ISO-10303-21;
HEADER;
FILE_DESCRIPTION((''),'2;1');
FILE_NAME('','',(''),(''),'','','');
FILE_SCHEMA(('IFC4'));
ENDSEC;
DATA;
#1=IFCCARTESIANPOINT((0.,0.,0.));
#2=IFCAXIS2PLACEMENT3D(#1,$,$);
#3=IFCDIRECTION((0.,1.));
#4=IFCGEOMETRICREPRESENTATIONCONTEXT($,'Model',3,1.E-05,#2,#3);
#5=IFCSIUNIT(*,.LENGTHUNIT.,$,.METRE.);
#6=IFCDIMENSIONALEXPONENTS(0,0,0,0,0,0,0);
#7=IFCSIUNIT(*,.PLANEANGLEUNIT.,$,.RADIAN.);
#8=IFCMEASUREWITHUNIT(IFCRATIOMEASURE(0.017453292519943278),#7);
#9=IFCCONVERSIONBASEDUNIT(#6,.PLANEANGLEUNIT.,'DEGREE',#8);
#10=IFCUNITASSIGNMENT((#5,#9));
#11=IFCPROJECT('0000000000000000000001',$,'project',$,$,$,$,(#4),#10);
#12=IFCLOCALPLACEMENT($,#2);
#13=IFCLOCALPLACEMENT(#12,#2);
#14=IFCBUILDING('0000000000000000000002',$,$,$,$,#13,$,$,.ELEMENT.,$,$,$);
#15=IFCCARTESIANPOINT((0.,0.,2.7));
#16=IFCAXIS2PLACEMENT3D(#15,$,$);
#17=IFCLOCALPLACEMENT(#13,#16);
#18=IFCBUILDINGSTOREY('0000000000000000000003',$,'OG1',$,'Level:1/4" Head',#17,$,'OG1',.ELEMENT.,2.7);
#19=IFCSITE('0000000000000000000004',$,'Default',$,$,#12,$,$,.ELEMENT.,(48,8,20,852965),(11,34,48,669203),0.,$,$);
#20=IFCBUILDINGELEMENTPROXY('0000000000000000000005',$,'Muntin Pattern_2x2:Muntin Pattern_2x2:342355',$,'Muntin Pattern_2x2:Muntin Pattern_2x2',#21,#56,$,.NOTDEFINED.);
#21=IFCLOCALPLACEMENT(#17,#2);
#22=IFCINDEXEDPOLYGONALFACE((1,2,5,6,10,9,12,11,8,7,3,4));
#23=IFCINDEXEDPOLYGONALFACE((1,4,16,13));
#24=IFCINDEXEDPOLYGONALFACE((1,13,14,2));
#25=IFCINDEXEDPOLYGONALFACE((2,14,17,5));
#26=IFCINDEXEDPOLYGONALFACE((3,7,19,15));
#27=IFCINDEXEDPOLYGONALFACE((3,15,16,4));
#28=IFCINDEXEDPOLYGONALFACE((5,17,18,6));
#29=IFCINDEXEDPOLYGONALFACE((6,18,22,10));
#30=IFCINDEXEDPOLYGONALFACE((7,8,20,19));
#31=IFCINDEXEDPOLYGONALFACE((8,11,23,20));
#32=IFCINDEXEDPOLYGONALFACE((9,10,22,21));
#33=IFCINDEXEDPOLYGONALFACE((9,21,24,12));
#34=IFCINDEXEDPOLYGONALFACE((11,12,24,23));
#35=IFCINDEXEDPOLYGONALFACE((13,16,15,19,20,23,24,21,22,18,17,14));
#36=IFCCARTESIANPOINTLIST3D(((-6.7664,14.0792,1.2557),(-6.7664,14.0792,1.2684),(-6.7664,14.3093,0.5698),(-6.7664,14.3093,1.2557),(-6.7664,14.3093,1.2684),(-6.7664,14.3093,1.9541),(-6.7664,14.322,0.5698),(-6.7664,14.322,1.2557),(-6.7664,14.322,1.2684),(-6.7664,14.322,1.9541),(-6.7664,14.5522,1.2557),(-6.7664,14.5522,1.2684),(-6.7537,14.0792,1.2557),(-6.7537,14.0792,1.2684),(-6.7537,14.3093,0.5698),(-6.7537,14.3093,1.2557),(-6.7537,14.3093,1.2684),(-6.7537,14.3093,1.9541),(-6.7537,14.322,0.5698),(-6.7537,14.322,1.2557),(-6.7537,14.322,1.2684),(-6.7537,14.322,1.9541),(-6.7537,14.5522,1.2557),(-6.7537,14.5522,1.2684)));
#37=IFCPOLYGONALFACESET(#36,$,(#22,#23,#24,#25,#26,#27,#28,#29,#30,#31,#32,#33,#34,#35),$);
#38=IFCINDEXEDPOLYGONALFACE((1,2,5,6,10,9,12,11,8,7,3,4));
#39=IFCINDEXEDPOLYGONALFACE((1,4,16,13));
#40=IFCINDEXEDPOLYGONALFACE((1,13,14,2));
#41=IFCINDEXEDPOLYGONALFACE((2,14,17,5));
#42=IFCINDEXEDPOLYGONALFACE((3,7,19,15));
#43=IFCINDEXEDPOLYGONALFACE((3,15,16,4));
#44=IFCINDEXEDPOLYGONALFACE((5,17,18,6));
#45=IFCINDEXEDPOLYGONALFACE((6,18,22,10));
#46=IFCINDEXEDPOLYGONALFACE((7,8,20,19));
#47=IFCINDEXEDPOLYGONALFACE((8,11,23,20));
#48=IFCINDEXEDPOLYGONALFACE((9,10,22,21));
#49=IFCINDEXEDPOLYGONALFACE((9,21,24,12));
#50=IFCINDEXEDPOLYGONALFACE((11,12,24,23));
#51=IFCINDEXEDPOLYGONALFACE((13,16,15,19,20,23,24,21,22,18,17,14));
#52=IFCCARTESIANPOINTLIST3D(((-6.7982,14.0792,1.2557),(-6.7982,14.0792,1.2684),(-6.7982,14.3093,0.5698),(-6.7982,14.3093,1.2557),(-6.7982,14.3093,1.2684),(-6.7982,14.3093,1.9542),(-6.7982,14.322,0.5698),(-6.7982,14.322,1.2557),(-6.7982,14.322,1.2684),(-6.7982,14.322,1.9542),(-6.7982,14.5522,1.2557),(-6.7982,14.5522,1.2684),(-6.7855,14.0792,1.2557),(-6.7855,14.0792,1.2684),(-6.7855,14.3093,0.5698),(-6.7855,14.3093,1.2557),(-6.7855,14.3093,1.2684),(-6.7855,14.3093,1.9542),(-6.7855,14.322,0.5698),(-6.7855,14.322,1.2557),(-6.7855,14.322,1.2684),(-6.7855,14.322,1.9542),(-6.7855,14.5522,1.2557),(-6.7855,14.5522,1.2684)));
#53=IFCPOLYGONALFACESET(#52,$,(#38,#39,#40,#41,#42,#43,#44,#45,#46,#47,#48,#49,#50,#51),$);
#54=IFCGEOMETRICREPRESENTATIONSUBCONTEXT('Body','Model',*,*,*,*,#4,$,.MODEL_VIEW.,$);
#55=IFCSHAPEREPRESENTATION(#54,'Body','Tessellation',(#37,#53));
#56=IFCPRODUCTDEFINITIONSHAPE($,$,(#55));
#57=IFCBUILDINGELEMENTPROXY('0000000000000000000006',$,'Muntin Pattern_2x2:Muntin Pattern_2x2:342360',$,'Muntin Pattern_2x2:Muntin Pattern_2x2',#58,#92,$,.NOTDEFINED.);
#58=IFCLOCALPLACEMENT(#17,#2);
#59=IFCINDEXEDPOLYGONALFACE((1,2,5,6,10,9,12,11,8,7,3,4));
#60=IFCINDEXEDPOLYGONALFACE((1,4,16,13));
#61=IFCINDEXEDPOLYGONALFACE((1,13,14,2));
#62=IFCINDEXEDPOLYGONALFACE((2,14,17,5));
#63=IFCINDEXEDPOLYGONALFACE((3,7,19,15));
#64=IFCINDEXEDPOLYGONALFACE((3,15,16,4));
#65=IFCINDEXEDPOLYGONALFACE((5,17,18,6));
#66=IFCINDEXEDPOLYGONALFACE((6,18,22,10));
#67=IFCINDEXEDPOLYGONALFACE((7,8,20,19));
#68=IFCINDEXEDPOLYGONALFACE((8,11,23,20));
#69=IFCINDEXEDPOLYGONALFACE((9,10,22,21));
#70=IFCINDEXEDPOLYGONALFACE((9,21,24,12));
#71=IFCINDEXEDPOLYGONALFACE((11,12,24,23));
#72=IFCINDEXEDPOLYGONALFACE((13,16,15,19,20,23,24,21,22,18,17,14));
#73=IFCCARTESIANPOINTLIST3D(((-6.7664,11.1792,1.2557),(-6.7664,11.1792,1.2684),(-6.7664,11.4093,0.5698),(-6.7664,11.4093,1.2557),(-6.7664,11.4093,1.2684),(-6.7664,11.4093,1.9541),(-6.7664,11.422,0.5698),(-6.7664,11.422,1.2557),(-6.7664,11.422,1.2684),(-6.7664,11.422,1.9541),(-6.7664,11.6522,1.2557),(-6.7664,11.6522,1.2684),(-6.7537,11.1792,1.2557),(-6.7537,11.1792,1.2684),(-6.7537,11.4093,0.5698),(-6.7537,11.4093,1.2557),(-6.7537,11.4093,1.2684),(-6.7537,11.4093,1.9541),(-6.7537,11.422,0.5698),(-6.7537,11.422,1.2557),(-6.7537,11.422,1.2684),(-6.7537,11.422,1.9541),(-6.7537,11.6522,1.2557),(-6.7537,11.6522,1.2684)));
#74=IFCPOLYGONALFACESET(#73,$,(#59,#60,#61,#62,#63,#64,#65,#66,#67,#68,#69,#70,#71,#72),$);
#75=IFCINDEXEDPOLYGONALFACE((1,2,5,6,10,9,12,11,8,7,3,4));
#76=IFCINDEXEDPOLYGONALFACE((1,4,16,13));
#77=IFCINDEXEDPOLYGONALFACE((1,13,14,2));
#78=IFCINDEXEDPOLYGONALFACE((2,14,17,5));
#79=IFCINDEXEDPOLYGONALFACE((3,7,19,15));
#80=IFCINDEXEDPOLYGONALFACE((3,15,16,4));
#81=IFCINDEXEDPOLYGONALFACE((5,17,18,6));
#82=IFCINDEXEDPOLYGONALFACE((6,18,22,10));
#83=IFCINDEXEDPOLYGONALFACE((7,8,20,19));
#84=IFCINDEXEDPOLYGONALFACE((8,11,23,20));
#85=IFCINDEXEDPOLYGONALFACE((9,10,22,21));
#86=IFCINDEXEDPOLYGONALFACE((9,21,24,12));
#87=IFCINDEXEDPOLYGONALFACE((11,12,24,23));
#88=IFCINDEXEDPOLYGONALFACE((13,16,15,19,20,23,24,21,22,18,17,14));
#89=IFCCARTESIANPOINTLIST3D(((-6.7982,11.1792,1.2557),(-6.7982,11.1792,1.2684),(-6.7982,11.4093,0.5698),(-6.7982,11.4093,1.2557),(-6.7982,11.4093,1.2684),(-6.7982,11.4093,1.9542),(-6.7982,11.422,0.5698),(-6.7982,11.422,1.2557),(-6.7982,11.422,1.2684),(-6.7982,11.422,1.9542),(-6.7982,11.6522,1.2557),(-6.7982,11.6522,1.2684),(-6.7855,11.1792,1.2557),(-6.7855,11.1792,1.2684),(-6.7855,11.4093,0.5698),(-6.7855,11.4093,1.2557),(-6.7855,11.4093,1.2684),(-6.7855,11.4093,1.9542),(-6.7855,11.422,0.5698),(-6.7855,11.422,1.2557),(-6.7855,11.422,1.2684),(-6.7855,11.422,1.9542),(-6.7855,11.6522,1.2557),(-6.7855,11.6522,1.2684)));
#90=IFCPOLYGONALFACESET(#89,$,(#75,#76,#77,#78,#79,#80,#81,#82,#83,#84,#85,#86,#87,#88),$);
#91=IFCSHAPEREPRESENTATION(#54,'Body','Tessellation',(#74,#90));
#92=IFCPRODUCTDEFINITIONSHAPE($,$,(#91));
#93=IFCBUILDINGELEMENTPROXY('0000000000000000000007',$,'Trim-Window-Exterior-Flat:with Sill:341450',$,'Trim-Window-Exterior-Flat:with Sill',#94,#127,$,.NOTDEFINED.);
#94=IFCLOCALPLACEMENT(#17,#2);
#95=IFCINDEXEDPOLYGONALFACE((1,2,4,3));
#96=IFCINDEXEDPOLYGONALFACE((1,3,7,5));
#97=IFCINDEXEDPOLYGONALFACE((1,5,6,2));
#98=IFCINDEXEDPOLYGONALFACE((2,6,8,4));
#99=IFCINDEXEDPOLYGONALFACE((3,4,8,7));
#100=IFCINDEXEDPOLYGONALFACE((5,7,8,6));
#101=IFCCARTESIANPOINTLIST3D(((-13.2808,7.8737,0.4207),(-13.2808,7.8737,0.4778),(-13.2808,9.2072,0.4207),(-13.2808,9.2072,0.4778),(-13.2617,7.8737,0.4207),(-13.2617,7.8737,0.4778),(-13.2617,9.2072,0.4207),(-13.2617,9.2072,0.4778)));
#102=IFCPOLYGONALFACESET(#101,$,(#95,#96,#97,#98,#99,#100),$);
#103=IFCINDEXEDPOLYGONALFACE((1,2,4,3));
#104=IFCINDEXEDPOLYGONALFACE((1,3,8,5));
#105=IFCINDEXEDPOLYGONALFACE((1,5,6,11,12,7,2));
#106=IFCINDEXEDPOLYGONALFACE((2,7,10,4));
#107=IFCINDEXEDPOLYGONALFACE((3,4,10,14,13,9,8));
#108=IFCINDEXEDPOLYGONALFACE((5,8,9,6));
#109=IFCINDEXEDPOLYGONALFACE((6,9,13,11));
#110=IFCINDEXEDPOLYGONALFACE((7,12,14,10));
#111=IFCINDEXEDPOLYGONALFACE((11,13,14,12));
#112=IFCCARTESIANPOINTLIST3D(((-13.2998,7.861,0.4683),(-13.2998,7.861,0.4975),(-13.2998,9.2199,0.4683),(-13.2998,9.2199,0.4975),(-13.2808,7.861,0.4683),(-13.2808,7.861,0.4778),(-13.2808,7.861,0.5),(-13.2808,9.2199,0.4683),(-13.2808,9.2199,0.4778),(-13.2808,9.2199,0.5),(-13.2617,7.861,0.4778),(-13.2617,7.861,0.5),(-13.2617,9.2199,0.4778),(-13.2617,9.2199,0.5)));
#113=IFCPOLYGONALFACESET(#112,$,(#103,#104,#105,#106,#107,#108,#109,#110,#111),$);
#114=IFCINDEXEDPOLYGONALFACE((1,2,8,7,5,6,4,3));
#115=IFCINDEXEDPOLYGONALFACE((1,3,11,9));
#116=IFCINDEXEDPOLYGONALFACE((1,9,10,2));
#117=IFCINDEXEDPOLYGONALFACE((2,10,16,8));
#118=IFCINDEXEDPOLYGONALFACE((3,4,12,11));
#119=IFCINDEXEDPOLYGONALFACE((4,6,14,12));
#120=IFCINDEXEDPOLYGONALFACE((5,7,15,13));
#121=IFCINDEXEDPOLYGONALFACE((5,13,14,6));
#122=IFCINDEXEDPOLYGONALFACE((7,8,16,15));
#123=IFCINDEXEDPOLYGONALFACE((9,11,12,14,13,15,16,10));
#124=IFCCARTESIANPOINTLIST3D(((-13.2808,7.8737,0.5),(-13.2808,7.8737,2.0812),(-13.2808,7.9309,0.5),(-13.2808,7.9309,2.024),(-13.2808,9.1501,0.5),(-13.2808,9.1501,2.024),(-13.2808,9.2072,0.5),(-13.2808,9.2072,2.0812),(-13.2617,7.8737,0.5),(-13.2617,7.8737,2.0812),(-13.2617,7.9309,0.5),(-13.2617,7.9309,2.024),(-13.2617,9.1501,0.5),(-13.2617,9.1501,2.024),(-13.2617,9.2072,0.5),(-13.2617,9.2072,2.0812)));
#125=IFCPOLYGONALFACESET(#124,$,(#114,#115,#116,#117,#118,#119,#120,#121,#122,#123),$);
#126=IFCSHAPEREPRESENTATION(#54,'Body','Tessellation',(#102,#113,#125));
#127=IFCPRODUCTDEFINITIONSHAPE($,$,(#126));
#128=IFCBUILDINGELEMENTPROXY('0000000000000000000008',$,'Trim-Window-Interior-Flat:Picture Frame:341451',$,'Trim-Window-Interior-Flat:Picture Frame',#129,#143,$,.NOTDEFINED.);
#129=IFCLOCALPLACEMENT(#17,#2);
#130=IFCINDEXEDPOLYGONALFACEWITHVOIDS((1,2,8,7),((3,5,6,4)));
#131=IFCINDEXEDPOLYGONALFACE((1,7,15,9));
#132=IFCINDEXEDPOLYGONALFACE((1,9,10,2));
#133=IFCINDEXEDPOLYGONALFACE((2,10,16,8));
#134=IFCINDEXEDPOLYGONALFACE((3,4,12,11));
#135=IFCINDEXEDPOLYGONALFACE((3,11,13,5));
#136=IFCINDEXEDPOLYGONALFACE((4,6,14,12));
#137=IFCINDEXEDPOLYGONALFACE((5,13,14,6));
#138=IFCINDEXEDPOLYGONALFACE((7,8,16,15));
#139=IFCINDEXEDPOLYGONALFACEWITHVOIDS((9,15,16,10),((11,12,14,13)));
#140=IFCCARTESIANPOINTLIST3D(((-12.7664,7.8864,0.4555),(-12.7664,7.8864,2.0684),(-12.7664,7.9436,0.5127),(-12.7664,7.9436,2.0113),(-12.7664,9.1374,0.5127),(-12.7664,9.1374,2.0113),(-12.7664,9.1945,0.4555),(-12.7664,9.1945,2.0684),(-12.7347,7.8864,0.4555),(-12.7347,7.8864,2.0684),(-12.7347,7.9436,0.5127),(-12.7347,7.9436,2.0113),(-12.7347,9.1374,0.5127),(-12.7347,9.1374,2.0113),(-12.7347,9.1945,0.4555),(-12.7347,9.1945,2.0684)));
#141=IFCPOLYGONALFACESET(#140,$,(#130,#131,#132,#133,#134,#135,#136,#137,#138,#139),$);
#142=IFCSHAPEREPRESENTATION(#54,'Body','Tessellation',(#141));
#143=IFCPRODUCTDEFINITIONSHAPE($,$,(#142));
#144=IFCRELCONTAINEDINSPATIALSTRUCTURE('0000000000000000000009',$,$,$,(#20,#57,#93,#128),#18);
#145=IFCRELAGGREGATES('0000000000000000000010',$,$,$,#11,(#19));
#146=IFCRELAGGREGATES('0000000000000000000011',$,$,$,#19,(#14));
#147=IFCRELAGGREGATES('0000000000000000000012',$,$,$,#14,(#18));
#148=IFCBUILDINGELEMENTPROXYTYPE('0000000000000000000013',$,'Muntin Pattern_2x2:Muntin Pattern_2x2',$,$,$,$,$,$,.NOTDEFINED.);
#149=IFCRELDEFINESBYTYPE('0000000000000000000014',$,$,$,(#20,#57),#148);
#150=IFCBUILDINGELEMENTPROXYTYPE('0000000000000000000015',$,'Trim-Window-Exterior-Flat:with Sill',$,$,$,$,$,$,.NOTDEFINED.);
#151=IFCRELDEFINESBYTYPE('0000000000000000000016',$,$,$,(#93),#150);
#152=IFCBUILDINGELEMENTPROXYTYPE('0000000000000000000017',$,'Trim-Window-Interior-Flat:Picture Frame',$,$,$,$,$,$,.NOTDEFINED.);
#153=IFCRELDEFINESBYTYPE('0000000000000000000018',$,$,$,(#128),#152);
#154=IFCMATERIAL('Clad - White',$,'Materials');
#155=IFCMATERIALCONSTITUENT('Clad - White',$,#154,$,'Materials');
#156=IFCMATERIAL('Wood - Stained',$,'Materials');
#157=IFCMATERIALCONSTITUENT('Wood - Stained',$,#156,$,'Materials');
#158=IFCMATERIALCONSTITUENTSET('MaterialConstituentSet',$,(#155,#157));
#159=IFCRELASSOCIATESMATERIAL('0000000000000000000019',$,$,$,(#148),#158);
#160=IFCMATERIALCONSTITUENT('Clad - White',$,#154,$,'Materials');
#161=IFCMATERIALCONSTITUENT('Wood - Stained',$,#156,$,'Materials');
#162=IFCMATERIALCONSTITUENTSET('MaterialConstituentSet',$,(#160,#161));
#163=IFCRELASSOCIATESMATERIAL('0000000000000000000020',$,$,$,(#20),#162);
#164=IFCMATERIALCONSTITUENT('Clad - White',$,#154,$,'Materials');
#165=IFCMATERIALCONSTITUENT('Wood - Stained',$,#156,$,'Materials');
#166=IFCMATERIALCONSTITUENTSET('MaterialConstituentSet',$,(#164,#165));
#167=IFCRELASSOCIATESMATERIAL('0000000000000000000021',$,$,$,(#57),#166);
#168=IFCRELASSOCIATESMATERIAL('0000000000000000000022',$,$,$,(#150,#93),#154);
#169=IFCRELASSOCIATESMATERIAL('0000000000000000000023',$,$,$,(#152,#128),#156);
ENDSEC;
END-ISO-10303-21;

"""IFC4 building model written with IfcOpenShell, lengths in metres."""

from ifc_helpers import new_model, entity, si_unit, converted_unit, direction, frame, origin, place, context, subcontext, project, spatial, indexed_curve, outline, extrude, source, transform, mapped, material, constituent, constituent_set, type_object, type_shapes, element, save


model = new_model("IFC4")

# Units and contexts
model_context = context("Model", 3, precision=1e-05, world=origin(), true_north=direction((0.0, 1.0)))
body_context = subcontext(model_context, "Body", "Model", "MODEL_VIEW")
ifc_project = project(units=[si_unit("LENGTHUNIT", "METRE"), converted_unit("PLANEANGLEUNIT", "DEGREE", entity("IfcRatioMeasure", 0.017453292519943278), si_unit("PLANEANGLEUNIT", "RADIAN"), dimensions=[0, 0, 0, 0, 0, 0, 0])], contexts=[model_context])

# Site, building, storey
site_placement = place(None, origin())
site = spatial("IfcSite", under=ifc_project, at=site_placement, Name="Default", CompositionType="ELEMENT", RefLatitude=(48, 8, 20, 852965), RefLongitude=(11, 34, 48, 669203), RefElevation=0.0)
building_placement = place(site_placement, origin())
building = spatial("IfcBuilding", under=site, at=building_placement, CompositionType="ELEMENT")
storey_placement = place(building_placement, frame((0.0, 0.0, 2.7)))
storey = spatial("IfcBuildingStorey", under=building, at=storey_placement, Name="OG1", ObjectType="Level:1/4\" Head", LongName="OG1", CompositionType="ELEMENT", Elevation=2.7)

# Building element proxies
ifc_material_1 = material(Name="Clad - White", Category="Materials")
ifc_material_2 = material(Name="Wood - Stained", Category="Materials")
ifc_constituent_1 = constituent(ifc_material_1, Name="Clad - White", Category="Materials")
ifc_constituent_2 = constituent(ifc_material_2, Name="Wood - Stained", Category="Materials")
ifc_constituent_set_1 = constituent_set(constituents=[ifc_constituent_1, ifc_constituent_2], Name="MaterialConstituentSet")
building_element_proxy_type_1 = type_object("IfcBuildingElementProxyType", Name="Muntin Pattern_2x2:Muntin Pattern_2x2", PredefinedType="NOTDEFINED", material=ifc_constituent_set_1)
shared_shape_1 = source(origin(), body_context, "Body", "SweptSolid", [
    extrude(outline(indexed_curve([(0.0064, -0.0064), (0.6921, -0.0064), (0.6921, 0.0063), (0.0064, 0.0063), (0.0064, 0.2365), (-0.0063, 0.2365), (-0.0063, 0.0063), (-0.6922, 0.0063), (-0.6922, -0.0064), (-0.0063, -0.0064), (-0.0063, -0.2365), (0.0064, -0.2365), (0.0064, -0.0064)], self_intersect=False)), frame((0.0, 0.0095, 0.6921), z_axis=(0.0, 1.0, 0.0), x_axis=(0.0, 0.0, 1.0)), (0.0, 0.0, 1.0), 0.0127),
    extrude(outline(indexed_curve([(0.0064, -0.0064), (0.6922, -0.0064), (0.6922, 0.0063), (0.0064, 0.0063), (0.0064, 0.2365), (-0.0063, 0.2365), (-0.0063, 0.0063), (-0.6922, 0.0063), (-0.6922, -0.0064), (-0.0063, -0.0064), (-0.0063, -0.2365), (0.0064, -0.2365), (0.0064, -0.0064)], self_intersect=False)), frame((0.0, -0.0222, 0.6922), z_axis=(0.0, 1.0, 0.0), x_axis=(0.0, 0.0, 1.0)), (0.0, 0.0, 1.0), 0.0127),
])
type_shapes(building_element_proxy_type_1, [shared_shape_1])
ifc_constituent_3 = constituent(ifc_material_1, Name="Clad - White", Category="Materials")
ifc_constituent_4 = constituent(ifc_material_2, Name="Wood - Stained", Category="Materials")
ifc_constituent_set_2 = constituent_set(constituents=[ifc_constituent_3, ifc_constituent_4], Name="MaterialConstituentSet")
proxy_1_placement = place(storey_placement, frame((-6.7759, 14.3157, 0.5699), z_axis=(0.0, 0.0, 1.0), x_axis=(0.0, -1.0, 0.0)))
element("IfcBuildingElementProxy", 1, at=proxy_1_placement, inside=storey, type_object=building_element_proxy_type_1, material=ifc_constituent_set_2, Name="Muntin Pattern_2x2:Muntin Pattern_2x2:342355", ObjectType="Muntin Pattern_2x2:Muntin Pattern_2x2", PredefinedType="NOTDEFINED", context=body_context, shape_type="MappedRepresentation", body=[
    mapped(shared_shape_1, transform((0.0, 0.0, 0.0), scale=1.0)),
])
ifc_constituent_5 = constituent(ifc_material_1, Name="Clad - White", Category="Materials")
ifc_constituent_6 = constituent(ifc_material_2, Name="Wood - Stained", Category="Materials")
ifc_constituent_set_3 = constituent_set(constituents=[ifc_constituent_5, ifc_constituent_6], Name="MaterialConstituentSet")
proxy_2_placement = place(storey_placement, frame((-6.7759, 11.4157, 0.5699), z_axis=(0.0, 0.0, 1.0), x_axis=(0.0, -1.0, 0.0)))
element("IfcBuildingElementProxy", 2, at=proxy_2_placement, inside=storey, type_object=building_element_proxy_type_1, material=ifc_constituent_set_3, Name="Muntin Pattern_2x2:Muntin Pattern_2x2:342360", ObjectType="Muntin Pattern_2x2:Muntin Pattern_2x2", PredefinedType="NOTDEFINED", context=body_context, shape_type="MappedRepresentation", body=[
    mapped(shared_shape_1, transform((0.0, 0.0, 0.0), scale=1.0)),
])
building_element_proxy_type_2 = type_object("IfcBuildingElementProxyType", Name="Trim-Window-Exterior-Flat:with Sill", PredefinedType="NOTDEFINED", material=ifc_material_1)
shared_shape_2 = source(origin(), body_context, "Body", "SweptSolid", [
    extrude(outline(indexed_curve([(-0.0286, -0.6667), (0.0286, -0.6667), (0.0286, 0.6667), (-0.0286, 0.6667), (-0.0286, -0.6667)], self_intersect=False)), frame((0.0, 1.5748, 0.0), z_axis=(0.0, 0.0, 1.0), x_axis=(0.0, 1.0, 0.0)), (0.0, 0.0, 1.0), 0.019),
    extrude(outline(indexed_curve([(-0.016, -0.019), (0.0133, -0.019), (0.0158, 0.0), (0.0158, 0.019), (-0.0064, 0.019), (-0.0064, 0.0), (-0.016, 0.0), (-0.016, -0.019)], self_intersect=False)), frame((-0.6794, 1.5398, 0.019), z_axis=(1.0, 0.0, 0.0), x_axis=(0.0, -1.0, 0.0)), (0.0, 0.0, 1.0), 1.3589),
    extrude(outline(indexed_curve([(-0.6667, -0.8049), (0.6667, -0.8049), (0.6667, 0.7763), (0.6096, 0.7763), (0.6096, -0.7477), (-0.6096, -0.7477), (-0.6096, 0.7763), (-0.6667, 0.7763), (-0.6667, -0.8049)], self_intersect=False)), frame((0.0, 0.7477, 0.0)), (0.0, 0.0, 1.0), 0.019),
])
type_shapes(building_element_proxy_type_2, [shared_shape_2])
proxy_3_placement = place(storey_placement, frame((-13.2617, 8.5405, 2.024), z_axis=(-1.0, 0.0, 0.0), x_axis=(0.0, 1.0, 0.0)))
element("IfcBuildingElementProxy", 3, at=proxy_3_placement, inside=storey, type_object=building_element_proxy_type_2, material=ifc_material_1, Name="Trim-Window-Exterior-Flat:with Sill:341450", ObjectType="Trim-Window-Exterior-Flat:with Sill", PredefinedType="NOTDEFINED", context=body_context, shape_type="MappedRepresentation", body=[
    mapped(shared_shape_2, transform((0.0, 0.0, 0.0), scale=1.0)),
])
building_element_proxy_type_3 = type_object("IfcBuildingElementProxyType", Name="Trim-Window-Interior-Flat:Picture Frame", PredefinedType="NOTDEFINED", material=ifc_material_2)
shared_shape_3 = source(origin(), body_context, "Body", "SweptSolid", [
    extrude(outline(indexed_curve([(-0.8064, -0.654), (0.8064, -0.654), (0.8064, 0.654), (-0.8064, 0.654), (-0.8064, -0.654)], self_intersect=False), holes=[indexed_curve([(-0.7493, -0.5969), (-0.7493, 0.5969), (0.7493, 0.5969), (0.7493, -0.5969), (-0.7493, -0.5969)], self_intersect=False)]), frame((0.0, 0.762, 0.0), z_axis=(0.0, 0.0, 1.0), x_axis=(0.0, 1.0, 0.0)), (0.0, 0.0, 1.0), 0.0317),
])
type_shapes(building_element_proxy_type_3, [shared_shape_3])
proxy_4_placement = place(storey_placement, frame((-12.7664, 8.5405, 2.024), z_axis=(1.0, 0.0, 0.0), x_axis=(0.0, -1.0, 0.0)))
element("IfcBuildingElementProxy", 4, at=proxy_4_placement, inside=storey, type_object=building_element_proxy_type_3, material=ifc_material_2, Name="Trim-Window-Interior-Flat:Picture Frame:341451", ObjectType="Trim-Window-Interior-Flat:Picture Frame", PredefinedType="NOTDEFINED", context=body_context, shape_type="MappedRepresentation", body=[
    mapped(shared_shape_3, transform((0.0, 0.0, 0.0), scale=1.0)),
])

save(model, "model.ifc")
